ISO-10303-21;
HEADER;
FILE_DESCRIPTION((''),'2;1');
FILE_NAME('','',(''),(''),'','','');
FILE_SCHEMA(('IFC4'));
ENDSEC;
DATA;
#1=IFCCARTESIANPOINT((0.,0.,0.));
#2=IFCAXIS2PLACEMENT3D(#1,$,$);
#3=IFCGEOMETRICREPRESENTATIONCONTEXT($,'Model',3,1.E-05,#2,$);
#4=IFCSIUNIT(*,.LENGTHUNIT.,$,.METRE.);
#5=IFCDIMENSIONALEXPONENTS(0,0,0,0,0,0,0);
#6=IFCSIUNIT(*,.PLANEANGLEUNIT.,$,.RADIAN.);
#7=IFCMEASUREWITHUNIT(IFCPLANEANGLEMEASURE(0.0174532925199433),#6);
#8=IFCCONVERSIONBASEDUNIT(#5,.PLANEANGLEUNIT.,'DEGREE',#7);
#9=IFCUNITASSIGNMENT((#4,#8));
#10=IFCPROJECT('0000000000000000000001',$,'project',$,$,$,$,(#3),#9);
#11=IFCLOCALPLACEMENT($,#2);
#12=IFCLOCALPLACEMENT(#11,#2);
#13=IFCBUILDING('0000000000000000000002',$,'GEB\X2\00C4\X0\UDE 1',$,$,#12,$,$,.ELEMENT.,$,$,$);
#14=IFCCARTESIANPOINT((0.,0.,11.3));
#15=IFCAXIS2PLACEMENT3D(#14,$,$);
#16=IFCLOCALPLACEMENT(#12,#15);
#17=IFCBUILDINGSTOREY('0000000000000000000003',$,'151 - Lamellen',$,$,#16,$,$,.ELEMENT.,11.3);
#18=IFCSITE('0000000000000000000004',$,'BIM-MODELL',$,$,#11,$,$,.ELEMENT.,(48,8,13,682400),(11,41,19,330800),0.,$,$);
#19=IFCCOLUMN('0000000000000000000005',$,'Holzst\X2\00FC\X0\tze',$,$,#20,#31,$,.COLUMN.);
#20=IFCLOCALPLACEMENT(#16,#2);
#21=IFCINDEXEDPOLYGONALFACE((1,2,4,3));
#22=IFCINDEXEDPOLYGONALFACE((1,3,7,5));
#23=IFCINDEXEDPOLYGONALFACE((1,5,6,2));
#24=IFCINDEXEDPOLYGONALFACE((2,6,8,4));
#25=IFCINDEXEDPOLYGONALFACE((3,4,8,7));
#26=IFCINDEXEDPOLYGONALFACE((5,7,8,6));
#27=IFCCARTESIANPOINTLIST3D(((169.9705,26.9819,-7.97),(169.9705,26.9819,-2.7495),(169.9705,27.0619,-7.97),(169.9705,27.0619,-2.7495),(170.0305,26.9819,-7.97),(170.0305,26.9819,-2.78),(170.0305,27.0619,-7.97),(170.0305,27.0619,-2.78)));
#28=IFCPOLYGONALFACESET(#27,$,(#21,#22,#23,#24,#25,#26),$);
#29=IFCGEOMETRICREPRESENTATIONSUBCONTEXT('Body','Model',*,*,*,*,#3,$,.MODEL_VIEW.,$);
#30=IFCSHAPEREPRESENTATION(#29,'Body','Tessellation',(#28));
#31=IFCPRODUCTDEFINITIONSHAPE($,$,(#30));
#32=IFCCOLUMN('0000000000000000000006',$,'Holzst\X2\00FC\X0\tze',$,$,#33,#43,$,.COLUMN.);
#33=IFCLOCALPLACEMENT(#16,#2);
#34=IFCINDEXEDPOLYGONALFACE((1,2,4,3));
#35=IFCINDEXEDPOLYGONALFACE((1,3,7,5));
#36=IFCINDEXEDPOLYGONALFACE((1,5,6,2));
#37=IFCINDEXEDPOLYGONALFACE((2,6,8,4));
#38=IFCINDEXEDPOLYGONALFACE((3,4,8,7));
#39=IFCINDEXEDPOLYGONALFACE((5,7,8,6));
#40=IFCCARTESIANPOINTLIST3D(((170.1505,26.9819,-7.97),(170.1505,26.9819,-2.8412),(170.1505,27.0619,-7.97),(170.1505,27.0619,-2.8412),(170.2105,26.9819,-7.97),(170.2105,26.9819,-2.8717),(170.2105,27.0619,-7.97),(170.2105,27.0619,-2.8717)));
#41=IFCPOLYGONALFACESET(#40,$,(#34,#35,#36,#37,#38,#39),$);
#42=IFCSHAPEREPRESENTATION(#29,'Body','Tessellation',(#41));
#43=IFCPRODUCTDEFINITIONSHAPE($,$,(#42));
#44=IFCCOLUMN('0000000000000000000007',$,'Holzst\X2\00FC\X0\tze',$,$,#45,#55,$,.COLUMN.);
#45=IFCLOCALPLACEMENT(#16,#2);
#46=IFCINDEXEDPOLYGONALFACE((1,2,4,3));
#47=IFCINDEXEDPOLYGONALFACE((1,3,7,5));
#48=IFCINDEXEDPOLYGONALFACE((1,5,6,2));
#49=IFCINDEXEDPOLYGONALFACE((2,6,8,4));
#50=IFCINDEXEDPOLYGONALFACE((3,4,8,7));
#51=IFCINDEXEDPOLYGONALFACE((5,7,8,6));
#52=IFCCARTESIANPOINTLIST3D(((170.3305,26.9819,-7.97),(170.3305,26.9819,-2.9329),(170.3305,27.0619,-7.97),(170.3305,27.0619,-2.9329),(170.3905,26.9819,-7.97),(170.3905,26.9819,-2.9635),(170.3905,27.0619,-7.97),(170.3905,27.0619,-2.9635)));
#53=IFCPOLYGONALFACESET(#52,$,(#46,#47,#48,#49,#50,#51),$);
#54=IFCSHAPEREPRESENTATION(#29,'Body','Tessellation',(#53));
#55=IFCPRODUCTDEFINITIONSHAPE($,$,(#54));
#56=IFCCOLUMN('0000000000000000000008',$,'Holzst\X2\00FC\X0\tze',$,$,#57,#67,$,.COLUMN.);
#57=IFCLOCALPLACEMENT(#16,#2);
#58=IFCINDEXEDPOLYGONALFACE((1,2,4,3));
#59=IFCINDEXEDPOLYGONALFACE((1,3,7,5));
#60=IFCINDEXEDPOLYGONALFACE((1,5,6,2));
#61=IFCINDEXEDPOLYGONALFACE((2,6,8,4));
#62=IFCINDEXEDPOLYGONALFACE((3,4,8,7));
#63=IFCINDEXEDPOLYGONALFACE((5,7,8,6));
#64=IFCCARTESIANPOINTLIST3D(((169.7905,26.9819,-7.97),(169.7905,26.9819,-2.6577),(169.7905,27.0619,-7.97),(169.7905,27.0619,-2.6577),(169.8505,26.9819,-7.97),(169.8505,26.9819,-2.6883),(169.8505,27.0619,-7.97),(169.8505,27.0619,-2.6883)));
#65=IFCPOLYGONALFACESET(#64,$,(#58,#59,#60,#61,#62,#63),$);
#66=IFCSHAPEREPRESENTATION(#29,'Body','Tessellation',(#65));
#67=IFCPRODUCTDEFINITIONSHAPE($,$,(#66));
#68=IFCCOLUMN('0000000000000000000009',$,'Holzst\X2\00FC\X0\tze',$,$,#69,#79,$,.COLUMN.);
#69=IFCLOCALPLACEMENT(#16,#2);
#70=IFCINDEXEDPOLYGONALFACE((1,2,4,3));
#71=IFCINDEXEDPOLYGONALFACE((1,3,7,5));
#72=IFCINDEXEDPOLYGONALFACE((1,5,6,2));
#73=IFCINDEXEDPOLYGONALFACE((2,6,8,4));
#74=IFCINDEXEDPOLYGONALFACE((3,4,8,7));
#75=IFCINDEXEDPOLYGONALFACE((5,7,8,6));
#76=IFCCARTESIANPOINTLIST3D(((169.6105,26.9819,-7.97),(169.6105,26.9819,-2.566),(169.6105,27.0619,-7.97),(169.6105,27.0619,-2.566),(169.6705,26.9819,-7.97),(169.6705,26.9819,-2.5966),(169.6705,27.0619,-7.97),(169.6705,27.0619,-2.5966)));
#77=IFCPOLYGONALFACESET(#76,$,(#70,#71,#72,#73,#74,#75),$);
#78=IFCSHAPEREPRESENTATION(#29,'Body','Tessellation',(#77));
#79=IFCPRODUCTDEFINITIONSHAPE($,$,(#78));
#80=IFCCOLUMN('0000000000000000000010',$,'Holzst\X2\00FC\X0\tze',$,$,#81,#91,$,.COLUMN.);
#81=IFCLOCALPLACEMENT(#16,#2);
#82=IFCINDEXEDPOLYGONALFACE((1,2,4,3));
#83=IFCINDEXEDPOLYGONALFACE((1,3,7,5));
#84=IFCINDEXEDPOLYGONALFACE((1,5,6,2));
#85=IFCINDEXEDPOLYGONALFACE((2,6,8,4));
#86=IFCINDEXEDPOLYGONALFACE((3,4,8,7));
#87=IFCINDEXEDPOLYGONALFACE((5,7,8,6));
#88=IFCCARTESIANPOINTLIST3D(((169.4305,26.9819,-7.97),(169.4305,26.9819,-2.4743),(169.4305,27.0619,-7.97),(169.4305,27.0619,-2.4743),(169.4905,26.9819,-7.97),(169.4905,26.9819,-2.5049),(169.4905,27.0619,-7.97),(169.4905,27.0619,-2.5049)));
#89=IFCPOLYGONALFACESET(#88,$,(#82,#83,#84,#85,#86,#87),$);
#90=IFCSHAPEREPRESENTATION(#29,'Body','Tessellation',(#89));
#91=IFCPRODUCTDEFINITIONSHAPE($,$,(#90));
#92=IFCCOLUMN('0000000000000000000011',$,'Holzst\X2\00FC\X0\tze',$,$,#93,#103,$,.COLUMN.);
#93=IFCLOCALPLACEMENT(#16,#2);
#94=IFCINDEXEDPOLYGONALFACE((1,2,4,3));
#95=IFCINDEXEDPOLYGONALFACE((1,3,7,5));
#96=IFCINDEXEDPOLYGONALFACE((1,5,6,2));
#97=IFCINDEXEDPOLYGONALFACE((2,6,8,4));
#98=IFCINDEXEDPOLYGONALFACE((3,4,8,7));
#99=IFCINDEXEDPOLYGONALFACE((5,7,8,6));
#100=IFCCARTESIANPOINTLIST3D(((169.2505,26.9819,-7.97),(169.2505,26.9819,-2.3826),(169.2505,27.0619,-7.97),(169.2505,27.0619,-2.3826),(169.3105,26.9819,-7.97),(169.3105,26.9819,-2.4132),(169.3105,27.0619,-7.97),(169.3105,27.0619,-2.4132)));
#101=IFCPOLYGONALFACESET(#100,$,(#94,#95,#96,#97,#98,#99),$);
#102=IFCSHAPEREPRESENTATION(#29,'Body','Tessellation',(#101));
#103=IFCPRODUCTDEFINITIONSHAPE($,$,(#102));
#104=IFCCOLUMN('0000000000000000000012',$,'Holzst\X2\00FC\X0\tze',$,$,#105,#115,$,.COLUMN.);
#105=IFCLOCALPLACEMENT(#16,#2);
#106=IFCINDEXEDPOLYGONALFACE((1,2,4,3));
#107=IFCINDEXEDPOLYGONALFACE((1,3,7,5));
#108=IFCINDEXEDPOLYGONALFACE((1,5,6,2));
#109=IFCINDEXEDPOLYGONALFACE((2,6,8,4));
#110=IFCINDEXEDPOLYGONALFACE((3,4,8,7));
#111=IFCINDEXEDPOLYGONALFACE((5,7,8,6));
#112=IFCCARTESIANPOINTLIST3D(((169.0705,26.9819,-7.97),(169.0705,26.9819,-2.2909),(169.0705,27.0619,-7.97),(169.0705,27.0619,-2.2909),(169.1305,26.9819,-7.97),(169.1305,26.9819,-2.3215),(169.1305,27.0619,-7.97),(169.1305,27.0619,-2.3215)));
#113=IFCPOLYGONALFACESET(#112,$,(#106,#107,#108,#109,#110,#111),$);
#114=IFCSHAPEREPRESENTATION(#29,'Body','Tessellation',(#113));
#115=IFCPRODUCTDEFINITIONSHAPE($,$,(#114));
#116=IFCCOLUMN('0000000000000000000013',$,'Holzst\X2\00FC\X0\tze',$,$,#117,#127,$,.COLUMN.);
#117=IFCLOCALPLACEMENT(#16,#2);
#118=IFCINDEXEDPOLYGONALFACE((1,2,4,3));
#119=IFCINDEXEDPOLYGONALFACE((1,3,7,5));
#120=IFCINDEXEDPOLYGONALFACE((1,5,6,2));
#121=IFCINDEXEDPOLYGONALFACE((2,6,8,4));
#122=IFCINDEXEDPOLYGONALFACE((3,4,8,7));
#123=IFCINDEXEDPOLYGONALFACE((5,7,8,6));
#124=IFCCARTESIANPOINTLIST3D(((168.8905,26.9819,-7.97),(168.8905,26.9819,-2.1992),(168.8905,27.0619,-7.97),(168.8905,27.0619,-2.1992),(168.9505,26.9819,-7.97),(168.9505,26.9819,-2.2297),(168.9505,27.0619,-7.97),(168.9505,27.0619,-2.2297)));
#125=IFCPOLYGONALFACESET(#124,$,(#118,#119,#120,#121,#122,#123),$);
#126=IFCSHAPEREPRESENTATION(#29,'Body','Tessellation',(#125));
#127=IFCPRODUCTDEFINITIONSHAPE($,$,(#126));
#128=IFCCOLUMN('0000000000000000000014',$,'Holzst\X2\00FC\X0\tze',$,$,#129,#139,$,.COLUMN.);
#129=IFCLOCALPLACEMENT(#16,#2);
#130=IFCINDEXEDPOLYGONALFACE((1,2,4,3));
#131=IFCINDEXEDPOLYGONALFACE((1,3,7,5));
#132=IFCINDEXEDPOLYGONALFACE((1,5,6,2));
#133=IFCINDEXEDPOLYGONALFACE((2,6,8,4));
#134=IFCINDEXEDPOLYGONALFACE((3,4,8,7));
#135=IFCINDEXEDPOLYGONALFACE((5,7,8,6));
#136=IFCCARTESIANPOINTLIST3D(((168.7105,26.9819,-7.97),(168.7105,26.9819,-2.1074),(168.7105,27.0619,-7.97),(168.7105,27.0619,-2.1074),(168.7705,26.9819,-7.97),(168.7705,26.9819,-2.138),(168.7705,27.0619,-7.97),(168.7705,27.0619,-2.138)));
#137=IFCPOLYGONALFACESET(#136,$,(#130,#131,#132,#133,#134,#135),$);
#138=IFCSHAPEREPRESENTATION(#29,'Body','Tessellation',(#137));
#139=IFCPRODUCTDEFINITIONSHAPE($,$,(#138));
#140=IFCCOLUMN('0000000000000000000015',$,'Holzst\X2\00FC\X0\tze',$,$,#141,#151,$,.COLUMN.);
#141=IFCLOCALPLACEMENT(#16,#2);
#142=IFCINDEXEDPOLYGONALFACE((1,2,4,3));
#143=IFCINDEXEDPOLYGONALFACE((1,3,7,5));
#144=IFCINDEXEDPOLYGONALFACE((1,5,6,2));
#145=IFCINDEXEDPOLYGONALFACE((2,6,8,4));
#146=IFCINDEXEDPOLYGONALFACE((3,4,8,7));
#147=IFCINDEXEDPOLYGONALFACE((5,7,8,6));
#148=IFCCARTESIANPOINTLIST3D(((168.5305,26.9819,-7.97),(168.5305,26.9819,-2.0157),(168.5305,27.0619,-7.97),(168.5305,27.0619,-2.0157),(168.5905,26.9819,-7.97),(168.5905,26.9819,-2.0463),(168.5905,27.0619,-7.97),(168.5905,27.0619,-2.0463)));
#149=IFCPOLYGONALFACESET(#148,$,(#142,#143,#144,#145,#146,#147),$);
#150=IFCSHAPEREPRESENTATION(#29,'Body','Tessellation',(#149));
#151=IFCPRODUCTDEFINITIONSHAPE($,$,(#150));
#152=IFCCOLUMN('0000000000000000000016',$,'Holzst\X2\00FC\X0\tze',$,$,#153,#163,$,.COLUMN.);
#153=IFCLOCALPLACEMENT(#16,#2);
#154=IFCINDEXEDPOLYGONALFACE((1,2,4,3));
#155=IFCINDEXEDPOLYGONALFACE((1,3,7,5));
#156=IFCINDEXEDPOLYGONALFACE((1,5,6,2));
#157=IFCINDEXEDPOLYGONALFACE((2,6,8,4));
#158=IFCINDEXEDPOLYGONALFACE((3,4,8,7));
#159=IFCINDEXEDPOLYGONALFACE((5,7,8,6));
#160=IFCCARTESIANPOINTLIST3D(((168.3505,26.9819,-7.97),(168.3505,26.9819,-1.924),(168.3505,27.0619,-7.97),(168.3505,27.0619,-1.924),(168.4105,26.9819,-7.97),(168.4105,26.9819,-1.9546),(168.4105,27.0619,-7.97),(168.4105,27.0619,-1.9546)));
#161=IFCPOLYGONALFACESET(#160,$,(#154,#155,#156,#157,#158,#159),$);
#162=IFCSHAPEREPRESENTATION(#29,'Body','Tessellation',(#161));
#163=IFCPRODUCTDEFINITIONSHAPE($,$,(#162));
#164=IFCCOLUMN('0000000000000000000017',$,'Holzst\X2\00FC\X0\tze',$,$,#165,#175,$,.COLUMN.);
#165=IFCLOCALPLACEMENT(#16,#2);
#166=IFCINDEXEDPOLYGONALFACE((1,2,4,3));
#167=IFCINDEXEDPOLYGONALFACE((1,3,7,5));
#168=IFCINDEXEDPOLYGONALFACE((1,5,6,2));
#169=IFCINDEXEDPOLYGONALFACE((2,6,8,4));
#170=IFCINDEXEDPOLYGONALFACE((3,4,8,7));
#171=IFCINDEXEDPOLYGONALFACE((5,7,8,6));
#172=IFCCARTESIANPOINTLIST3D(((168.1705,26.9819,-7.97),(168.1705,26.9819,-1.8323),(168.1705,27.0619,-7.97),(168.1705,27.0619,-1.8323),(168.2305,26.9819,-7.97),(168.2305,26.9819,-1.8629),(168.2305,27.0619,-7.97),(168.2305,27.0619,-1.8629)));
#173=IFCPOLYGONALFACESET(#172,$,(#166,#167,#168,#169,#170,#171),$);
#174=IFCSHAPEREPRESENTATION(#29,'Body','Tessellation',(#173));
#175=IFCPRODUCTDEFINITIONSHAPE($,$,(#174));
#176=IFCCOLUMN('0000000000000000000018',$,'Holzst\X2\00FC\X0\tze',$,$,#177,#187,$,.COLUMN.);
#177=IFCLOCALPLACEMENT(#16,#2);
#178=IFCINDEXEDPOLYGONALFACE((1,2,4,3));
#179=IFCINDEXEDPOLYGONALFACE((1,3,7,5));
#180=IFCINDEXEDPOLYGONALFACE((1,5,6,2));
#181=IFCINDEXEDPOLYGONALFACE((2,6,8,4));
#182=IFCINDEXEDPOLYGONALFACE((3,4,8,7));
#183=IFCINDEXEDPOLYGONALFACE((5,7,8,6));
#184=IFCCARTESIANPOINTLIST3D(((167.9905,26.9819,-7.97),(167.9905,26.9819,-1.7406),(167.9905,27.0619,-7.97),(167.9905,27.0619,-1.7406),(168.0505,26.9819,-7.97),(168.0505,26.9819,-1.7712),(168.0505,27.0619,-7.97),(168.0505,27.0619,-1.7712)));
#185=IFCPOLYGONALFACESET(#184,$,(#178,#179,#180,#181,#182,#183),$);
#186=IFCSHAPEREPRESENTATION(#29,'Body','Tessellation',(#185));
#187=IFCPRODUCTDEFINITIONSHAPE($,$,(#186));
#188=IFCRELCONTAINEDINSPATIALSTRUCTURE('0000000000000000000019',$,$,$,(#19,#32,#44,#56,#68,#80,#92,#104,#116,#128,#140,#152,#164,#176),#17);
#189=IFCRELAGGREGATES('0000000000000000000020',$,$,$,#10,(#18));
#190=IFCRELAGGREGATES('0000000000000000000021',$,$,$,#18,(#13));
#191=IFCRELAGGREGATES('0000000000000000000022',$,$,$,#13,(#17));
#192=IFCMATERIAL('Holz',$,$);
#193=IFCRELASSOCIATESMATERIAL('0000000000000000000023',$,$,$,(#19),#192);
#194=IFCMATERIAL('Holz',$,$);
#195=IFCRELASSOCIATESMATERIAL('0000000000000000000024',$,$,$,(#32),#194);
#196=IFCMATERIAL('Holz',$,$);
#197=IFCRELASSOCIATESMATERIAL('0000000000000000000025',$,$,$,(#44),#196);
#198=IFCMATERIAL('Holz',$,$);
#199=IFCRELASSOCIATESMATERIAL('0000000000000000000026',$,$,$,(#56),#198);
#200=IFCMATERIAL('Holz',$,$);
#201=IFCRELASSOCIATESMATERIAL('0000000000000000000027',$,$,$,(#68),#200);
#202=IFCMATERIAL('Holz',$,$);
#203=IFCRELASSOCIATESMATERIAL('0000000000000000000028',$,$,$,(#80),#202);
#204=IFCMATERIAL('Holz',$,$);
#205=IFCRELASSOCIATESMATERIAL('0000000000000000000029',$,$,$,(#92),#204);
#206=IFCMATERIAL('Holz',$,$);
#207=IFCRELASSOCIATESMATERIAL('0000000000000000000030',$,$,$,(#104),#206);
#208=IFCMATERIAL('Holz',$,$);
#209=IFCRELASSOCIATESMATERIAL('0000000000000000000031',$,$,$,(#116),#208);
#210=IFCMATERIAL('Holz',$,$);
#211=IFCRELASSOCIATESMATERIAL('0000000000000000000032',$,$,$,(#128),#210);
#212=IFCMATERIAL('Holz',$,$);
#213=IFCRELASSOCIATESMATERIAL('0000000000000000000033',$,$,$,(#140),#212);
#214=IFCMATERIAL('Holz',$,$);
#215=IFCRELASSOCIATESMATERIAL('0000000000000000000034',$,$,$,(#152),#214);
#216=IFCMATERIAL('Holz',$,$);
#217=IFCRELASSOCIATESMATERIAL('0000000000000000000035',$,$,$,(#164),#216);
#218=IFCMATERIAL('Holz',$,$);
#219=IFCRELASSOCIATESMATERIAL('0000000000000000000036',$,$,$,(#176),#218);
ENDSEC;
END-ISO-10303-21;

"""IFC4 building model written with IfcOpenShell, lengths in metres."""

from ifc_helpers import new_model, entity, si_unit, converted_unit, frame, frame_2d, origin, origin_with_axes, place, context, subcontext, project, spatial, rectangle, extrude, clip, halfspace, material, element, save


model = new_model("IFC4")

# Units and contexts
model_context = context("Model", 3, precision=1e-05, world=origin())
body_context = subcontext(model_context, "Body", "Model", "MODEL_VIEW")
ifc_project = project(units=[si_unit("LENGTHUNIT", "METRE"), converted_unit("PLANEANGLEUNIT", "DEGREE", entity("IfcPlaneAngleMeasure", 0.0174532925199433), si_unit("PLANEANGLEUNIT", "RADIAN"), dimensions=[0, 0, 0, 0, 0, 0, 0])], contexts=[model_context])

# Site, building, storey
site_placement = place(None, origin())
site = spatial("IfcSite", under=ifc_project, at=site_placement, Name="BIM-MODELL", CompositionType="ELEMENT", RefLatitude=(48, 8, 13, 682400), RefLongitude=(11, 41, 19, 330800), RefElevation=0.0)
building_placement = place(site_placement, origin())
building = spatial("IfcBuilding", under=site, at=building_placement, Name="GEBÄUDE 1", CompositionType="ELEMENT")
storey_placement = place(building_placement, frame((0.0, 0.0, 11.3)))
storey = spatial("IfcBuildingStorey", under=building, at=storey_placement, Name="151 - Lamellen", CompositionType="ELEMENT", Elevation=11.3)

# Columns
ifc_material_1 = material(Name="Holz")
column_1_placement = place(storey_placement, frame((169.9705, 26.9819, -7.97)))
element("IfcColumn", 1, at=column_1_placement, inside=storey, material=ifc_material_1, Name="Holzstütze", PredefinedType="COLUMN", context=body_context, shape_type="Clipping", body=[
    clip(extrude(rectangle(XDim=0.06, YDim=0.08, at=frame_2d((0.03, 0.04), x_axis=(1.0, 0.0))), origin_with_axes(), (0.0, 0.0, 1.0), 5.2205), halfspace(frame((0.03, 0.04, 5.2053), z_axis=(-0.45399, 0.0, -0.891007), x_axis=(0.0, -1.0, 0.0)), True)),
])
ifc_material_2 = material(Name="Holz")
column_2_placement = place(storey_placement, frame((170.1505, 26.9819, -7.97)))
element("IfcColumn", 2, at=column_2_placement, inside=storey, material=ifc_material_2, Name="Holzstütze", PredefinedType="COLUMN", context=body_context, shape_type="Clipping", body=[
    clip(extrude(rectangle(XDim=0.06, YDim=0.08, at=frame_2d((0.03, 0.04), x_axis=(1.0, 0.0))), origin_with_axes(), (0.0, 0.0, 1.0), 5.1288), halfspace(frame((0.03, 0.04, 5.1135), z_axis=(-0.45399, 0.0, -0.891007), x_axis=(0.0, -1.0, 0.0)), True)),
])
ifc_material_3 = material(Name="Holz")
column_3_placement = place(storey_placement, frame((170.3305, 26.9819, -7.97)))
element("IfcColumn", 3, at=column_3_placement, inside=storey, material=ifc_material_3, Name="Holzstütze", PredefinedType="COLUMN", context=body_context, shape_type="Clipping", body=[
    clip(extrude(rectangle(XDim=0.06, YDim=0.08, at=frame_2d((0.03, 0.04), x_axis=(1.0, 0.0))), origin_with_axes(), (0.0, 0.0, 1.0), 5.0371), halfspace(frame((0.03, 0.04, 5.0218), z_axis=(-0.45399, 0.0, -0.891007), x_axis=(0.0, -1.0, 0.0)), True)),
])
ifc_material_4 = material(Name="Holz")
column_4_placement = place(storey_placement, frame((169.7905, 26.9819, -7.97)))
element("IfcColumn", 4, at=column_4_placement, inside=storey, material=ifc_material_4, Name="Holzstütze", PredefinedType="COLUMN", context=body_context, shape_type="Clipping", body=[
    clip(extrude(rectangle(XDim=0.06, YDim=0.08, at=frame_2d((0.03, 0.04), x_axis=(1.0, 0.0))), origin_with_axes(), (0.0, 0.0, 1.0), 5.3123), halfspace(frame((0.03, 0.04, 5.297), z_axis=(-0.45399, 0.0, -0.891007), x_axis=(0.0, -1.0, 0.0)), True)),
])
ifc_material_5 = material(Name="Holz")
column_5_placement = place(storey_placement, frame((169.6105, 26.9819, -7.97)))
element("IfcColumn", 5, at=column_5_placement, inside=storey, material=ifc_material_5, Name="Holzstütze", PredefinedType="COLUMN", context=body_context, shape_type="Clipping", body=[
    clip(extrude(rectangle(XDim=0.06, YDim=0.08, at=frame_2d((0.03, 0.04), x_axis=(1.0, 0.0))), origin_with_axes(), (0.0, 0.0, 1.0), 5.404), halfspace(frame((0.03, 0.04, 5.3887), z_axis=(-0.45399, 0.0, -0.891007), x_axis=(0.0, -1.0, 0.0)), True)),
])
ifc_material_6 = material(Name="Holz")
column_6_placement = place(storey_placement, frame((169.4305, 26.9819, -7.97)))
element("IfcColumn", 6, at=column_6_placement, inside=storey, material=ifc_material_6, Name="Holzstütze", PredefinedType="COLUMN", context=body_context, shape_type="Clipping", body=[
    clip(extrude(rectangle(XDim=0.06, YDim=0.08, at=frame_2d((0.03, 0.04), x_axis=(1.0, 0.0))), origin_with_axes(), (0.0, 0.0, 1.0), 5.4957), halfspace(frame((0.03, 0.04, 5.4804), z_axis=(-0.45399, 0.0, -0.891007), x_axis=(0.0, -1.0, 0.0)), True)),
])
ifc_material_7 = material(Name="Holz")
column_7_placement = place(storey_placement, frame((169.2505, 26.9819, -7.97)))
element("IfcColumn", 7, at=column_7_placement, inside=storey, material=ifc_material_7, Name="Holzstütze", PredefinedType="COLUMN", context=body_context, shape_type="Clipping", body=[
    clip(extrude(rectangle(XDim=0.06, YDim=0.08, at=frame_2d((0.03, 0.04), x_axis=(1.0, 0.0))), origin_with_axes(), (0.0, 0.0, 1.0), 5.5874), halfspace(frame((0.03, 0.04, 5.5721), z_axis=(-0.45399, 0.0, -0.891007), x_axis=(0.0, -1.0, 0.0)), True)),
])
ifc_material_8 = material(Name="Holz")
column_8_placement = place(storey_placement, frame((169.0705, 26.9819, -7.97)))
element("IfcColumn", 8, at=column_8_placement, inside=storey, material=ifc_material_8, Name="Holzstütze", PredefinedType="COLUMN", context=body_context, shape_type="Clipping", body=[
    clip(extrude(rectangle(XDim=0.06, YDim=0.08, at=frame_2d((0.03, 0.04), x_axis=(1.0, 0.0))), origin_with_axes(), (0.0, 0.0, 1.0), 5.6791), halfspace(frame((0.03, 0.04, 5.6638), z_axis=(-0.45399, 0.0, -0.891007), x_axis=(0.0, -1.0, 0.0)), True)),
])
ifc_material_9 = material(Name="Holz")
column_9_placement = place(storey_placement, frame((168.8905, 26.9819, -7.97)))
element("IfcColumn", 9, at=column_9_placement, inside=storey, material=ifc_material_9, Name="Holzstütze", PredefinedType="COLUMN", context=body_context, shape_type="Clipping", body=[
    clip(extrude(rectangle(XDim=0.06, YDim=0.08, at=frame_2d((0.03, 0.04), x_axis=(1.0, 0.0))), origin_with_axes(), (0.0, 0.0, 1.0), 5.7708), halfspace(frame((0.03, 0.04, 5.7555), z_axis=(-0.45399, 0.0, -0.891007), x_axis=(0.0, -1.0, 0.0)), True)),
])
ifc_material_10 = material(Name="Holz")
column_10_placement = place(storey_placement, frame((168.7105, 26.9819, -7.97)))
element("IfcColumn", 10, at=column_10_placement, inside=storey, material=ifc_material_10, Name="Holzstütze", PredefinedType="COLUMN", context=body_context, shape_type="Clipping", body=[
    clip(extrude(rectangle(XDim=0.06, YDim=0.08, at=frame_2d((0.03, 0.04), x_axis=(1.0, 0.0))), origin_with_axes(), (0.0, 0.0, 1.0), 5.8626), halfspace(frame((0.03, 0.04, 5.8473), z_axis=(-0.45399, 0.0, -0.891007), x_axis=(0.0, -1.0, 0.0)), True)),
])
ifc_material_11 = material(Name="Holz")
column_11_placement = place(storey_placement, frame((168.5305, 26.9819, -7.97)))
element("IfcColumn", 11, at=column_11_placement, inside=storey, material=ifc_material_11, Name="Holzstütze", PredefinedType="COLUMN", context=body_context, shape_type="Clipping", body=[
    clip(extrude(rectangle(XDim=0.06, YDim=0.08, at=frame_2d((0.03, 0.04), x_axis=(1.0, 0.0))), origin_with_axes(), (0.0, 0.0, 1.0), 5.9543), halfspace(frame((0.03, 0.04, 5.939), z_axis=(-0.45399, 0.0, -0.891007), x_axis=(0.0, -1.0, 0.0)), True)),
])
ifc_material_12 = material(Name="Holz")
column_12_placement = place(storey_placement, frame((168.3505, 26.9819, -7.97)))
element("IfcColumn", 12, at=column_12_placement, inside=storey, material=ifc_material_12, Name="Holzstütze", PredefinedType="COLUMN", context=body_context, shape_type="Clipping", body=[
    clip(extrude(rectangle(XDim=0.06, YDim=0.08, at=frame_2d((0.03, 0.04), x_axis=(1.0, 0.0))), origin_with_axes(), (0.0, 0.0, 1.0), 6.046), halfspace(frame((0.03, 0.04, 6.0307), z_axis=(-0.45399, 0.0, -0.891007), x_axis=(0.0, -1.0, 0.0)), True)),
])
ifc_material_13 = material(Name="Holz")
column_13_placement = place(storey_placement, frame((168.1705, 26.9819, -7.97)))
element("IfcColumn", 13, at=column_13_placement, inside=storey, material=ifc_material_13, Name="Holzstütze", PredefinedType="COLUMN", context=body_context, shape_type="Clipping", body=[
    clip(extrude(rectangle(XDim=0.06, YDim=0.08, at=frame_2d((0.03, 0.04), x_axis=(1.0, 0.0))), origin_with_axes(), (0.0, 0.0, 1.0), 6.1377), halfspace(frame((0.03, 0.04, 6.1224), z_axis=(-0.45399, 0.0, -0.891007), x_axis=(0.0, -1.0, 0.0)), True)),
])
ifc_material_14 = material(Name="Holz")
column_14_placement = place(storey_placement, frame((167.9905, 26.9819, -7.97)))
element("IfcColumn", 14, at=column_14_placement, inside=storey, material=ifc_material_14, Name="Holzstütze", PredefinedType="COLUMN", context=body_context, shape_type="Clipping", body=[
    clip(extrude(rectangle(XDim=0.06, YDim=0.08, at=frame_2d((0.03, 0.04), x_axis=(1.0, 0.0))), origin_with_axes(), (0.0, 0.0, 1.0), 6.2294), halfspace(frame((0.03, 0.04, 6.2141), z_axis=(-0.45399, 0.0, -0.891007), x_axis=(0.0, -1.0, 0.0)), True)),
])

save(model, "model.ifc")
